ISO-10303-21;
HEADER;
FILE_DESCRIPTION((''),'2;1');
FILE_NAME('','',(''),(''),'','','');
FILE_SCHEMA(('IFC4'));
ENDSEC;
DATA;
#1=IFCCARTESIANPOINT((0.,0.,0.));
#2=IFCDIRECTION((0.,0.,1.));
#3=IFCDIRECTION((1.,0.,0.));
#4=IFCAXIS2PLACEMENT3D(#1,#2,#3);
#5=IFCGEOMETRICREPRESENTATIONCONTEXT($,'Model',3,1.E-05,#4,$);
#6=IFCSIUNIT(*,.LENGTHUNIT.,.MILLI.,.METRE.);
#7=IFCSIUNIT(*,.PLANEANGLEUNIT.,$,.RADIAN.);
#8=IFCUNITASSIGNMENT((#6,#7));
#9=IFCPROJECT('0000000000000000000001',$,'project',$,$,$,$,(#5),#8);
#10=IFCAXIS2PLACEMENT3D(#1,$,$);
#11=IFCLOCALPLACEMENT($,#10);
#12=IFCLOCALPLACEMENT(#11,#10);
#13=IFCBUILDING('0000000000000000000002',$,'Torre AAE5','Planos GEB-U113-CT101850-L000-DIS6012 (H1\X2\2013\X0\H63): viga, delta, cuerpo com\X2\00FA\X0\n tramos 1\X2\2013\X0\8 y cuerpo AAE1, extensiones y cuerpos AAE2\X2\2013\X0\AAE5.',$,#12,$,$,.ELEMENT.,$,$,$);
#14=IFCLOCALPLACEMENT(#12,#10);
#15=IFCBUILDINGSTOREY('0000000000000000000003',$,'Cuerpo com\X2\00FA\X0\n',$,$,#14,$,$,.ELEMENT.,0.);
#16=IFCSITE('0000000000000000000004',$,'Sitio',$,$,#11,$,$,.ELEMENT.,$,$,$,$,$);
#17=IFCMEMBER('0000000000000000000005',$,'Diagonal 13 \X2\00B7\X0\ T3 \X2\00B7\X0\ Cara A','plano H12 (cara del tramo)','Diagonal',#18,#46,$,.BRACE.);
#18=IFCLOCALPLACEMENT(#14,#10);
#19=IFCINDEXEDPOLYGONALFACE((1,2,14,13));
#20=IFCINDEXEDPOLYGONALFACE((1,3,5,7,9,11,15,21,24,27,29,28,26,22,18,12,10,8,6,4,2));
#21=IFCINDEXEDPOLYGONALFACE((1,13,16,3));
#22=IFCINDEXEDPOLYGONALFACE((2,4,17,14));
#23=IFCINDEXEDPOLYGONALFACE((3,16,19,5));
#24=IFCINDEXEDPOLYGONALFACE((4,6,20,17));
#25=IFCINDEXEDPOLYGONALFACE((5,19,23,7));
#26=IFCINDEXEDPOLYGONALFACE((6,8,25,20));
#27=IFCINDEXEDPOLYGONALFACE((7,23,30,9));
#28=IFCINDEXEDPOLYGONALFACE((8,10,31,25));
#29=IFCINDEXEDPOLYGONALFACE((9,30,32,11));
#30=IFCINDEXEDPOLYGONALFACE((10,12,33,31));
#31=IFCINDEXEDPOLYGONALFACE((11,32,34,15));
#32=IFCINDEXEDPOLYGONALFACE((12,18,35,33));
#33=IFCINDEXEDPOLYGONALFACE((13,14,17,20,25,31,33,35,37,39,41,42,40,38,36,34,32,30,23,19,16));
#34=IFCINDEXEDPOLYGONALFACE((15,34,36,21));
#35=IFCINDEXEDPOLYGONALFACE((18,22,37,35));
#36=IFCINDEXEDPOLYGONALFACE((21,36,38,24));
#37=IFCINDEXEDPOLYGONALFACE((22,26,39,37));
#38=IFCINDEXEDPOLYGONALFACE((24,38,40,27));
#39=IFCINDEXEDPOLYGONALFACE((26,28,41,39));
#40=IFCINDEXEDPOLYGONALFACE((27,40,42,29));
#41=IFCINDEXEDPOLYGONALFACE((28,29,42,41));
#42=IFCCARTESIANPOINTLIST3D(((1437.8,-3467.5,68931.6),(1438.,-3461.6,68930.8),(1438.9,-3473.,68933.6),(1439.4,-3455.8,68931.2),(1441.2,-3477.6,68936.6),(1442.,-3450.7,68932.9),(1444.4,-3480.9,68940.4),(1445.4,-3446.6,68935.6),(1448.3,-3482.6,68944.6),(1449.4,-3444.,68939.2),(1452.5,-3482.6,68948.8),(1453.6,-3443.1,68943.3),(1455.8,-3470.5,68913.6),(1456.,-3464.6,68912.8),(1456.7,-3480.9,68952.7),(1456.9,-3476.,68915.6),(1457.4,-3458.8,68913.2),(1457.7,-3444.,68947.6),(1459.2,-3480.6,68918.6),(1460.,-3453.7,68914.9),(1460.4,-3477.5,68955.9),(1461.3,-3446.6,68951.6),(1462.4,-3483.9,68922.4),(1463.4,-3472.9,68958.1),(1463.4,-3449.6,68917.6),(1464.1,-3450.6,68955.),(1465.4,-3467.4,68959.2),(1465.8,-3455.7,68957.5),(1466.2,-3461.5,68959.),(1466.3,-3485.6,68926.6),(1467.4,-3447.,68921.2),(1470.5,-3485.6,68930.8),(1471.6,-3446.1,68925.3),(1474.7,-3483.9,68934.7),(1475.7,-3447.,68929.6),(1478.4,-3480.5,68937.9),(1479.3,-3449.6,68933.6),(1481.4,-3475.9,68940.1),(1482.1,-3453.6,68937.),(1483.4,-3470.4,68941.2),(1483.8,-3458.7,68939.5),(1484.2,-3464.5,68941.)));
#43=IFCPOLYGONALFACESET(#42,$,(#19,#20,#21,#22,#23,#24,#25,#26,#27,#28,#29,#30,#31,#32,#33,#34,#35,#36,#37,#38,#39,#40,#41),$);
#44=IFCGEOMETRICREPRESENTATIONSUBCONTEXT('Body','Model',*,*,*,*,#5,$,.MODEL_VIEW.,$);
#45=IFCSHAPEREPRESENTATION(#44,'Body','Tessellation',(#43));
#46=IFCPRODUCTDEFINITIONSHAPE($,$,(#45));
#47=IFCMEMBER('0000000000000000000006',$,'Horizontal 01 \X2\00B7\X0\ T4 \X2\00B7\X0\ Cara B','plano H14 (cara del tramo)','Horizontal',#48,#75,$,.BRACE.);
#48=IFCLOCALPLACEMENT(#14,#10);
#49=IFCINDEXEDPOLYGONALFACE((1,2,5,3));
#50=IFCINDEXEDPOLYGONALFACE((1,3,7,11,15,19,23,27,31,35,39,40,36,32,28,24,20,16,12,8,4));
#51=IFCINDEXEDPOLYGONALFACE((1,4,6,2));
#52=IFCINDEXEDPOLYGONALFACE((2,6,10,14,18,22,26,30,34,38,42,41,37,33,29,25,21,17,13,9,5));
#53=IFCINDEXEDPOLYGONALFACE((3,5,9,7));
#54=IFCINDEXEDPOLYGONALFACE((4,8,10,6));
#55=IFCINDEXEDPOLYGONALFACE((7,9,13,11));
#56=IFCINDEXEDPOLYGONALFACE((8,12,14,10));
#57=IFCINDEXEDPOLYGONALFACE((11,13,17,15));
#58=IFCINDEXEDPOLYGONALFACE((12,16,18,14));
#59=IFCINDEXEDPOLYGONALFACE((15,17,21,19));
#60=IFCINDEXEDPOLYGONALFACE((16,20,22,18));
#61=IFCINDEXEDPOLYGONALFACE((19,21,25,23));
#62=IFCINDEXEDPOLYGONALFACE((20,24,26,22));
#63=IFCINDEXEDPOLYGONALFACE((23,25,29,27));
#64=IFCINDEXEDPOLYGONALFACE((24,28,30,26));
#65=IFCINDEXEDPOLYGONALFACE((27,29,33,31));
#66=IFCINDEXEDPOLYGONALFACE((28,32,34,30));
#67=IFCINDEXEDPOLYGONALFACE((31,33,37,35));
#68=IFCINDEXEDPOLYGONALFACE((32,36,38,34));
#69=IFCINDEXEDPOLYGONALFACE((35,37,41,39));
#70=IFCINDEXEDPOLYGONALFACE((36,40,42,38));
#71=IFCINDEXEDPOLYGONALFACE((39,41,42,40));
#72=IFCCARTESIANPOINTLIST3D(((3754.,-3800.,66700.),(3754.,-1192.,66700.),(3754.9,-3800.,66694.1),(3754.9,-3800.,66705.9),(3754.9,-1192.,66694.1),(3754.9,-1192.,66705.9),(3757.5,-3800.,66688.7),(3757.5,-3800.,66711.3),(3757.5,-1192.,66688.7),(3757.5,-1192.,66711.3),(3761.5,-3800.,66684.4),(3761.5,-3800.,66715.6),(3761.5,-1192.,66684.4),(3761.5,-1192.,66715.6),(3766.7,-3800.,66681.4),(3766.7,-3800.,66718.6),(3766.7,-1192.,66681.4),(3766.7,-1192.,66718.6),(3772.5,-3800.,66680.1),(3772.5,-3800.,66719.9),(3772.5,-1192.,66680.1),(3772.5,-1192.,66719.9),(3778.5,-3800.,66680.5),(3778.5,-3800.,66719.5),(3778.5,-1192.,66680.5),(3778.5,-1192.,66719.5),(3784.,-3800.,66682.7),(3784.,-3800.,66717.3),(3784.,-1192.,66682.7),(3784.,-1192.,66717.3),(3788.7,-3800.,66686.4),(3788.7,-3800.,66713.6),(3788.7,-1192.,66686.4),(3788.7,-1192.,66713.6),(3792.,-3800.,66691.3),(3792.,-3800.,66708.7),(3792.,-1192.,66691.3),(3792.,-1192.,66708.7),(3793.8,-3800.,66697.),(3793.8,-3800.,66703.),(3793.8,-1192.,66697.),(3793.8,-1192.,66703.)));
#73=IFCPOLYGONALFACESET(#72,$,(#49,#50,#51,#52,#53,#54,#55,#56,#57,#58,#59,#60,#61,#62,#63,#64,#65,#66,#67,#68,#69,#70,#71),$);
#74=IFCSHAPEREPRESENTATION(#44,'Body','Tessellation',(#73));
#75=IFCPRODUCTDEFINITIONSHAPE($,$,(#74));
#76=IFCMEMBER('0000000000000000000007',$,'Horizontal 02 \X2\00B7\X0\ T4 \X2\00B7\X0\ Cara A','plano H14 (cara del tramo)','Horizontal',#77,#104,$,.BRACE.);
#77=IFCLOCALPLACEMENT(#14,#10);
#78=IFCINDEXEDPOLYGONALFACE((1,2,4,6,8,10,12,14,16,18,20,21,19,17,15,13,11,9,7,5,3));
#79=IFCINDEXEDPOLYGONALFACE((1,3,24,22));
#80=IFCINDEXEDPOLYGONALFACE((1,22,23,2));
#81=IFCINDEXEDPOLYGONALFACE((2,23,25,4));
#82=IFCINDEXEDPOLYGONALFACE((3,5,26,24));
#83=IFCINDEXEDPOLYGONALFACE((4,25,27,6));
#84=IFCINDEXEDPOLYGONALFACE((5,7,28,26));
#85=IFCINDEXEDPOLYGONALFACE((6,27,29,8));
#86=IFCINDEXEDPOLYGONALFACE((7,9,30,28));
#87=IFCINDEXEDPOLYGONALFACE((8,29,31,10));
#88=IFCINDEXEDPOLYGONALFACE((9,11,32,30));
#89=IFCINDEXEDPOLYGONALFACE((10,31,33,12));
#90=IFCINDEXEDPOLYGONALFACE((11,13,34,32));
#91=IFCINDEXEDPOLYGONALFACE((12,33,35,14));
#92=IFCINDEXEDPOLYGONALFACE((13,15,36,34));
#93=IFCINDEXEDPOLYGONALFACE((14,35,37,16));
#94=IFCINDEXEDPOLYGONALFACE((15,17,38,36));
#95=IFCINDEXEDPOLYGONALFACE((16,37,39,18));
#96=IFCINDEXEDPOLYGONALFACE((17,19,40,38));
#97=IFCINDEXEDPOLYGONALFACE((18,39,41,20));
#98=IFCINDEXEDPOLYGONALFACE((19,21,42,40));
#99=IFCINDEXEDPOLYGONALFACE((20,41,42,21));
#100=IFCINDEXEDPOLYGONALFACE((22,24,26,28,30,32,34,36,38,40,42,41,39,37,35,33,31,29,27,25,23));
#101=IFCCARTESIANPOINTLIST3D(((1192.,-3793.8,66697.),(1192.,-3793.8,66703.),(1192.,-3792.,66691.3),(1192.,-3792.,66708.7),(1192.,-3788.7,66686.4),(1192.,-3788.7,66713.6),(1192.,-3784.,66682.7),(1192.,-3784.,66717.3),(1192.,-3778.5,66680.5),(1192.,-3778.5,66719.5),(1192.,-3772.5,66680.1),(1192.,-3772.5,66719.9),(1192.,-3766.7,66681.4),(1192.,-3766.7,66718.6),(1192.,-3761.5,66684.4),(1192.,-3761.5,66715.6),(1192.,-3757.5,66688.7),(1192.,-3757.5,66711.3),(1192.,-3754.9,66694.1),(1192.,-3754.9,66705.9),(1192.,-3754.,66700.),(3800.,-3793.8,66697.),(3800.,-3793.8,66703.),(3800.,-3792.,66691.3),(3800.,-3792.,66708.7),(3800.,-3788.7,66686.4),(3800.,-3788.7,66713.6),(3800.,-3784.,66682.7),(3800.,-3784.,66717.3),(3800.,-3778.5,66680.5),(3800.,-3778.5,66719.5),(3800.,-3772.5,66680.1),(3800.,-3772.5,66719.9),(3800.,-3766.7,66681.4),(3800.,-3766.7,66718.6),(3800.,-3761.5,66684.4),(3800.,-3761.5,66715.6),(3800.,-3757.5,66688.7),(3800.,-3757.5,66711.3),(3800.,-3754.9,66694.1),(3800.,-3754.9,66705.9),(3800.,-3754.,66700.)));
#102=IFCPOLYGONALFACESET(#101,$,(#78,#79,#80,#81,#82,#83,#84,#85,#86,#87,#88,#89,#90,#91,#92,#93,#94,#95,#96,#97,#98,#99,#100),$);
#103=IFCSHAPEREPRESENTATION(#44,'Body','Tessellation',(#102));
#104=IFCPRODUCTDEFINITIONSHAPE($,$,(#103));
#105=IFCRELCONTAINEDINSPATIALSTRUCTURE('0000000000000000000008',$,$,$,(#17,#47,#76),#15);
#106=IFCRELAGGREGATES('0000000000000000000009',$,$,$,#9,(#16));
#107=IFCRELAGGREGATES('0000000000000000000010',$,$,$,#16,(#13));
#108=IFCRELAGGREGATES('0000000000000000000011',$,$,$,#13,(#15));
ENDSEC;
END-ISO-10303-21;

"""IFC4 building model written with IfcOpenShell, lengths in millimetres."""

from ifc_helpers import new_model, si_unit, frame, origin, origin_with_axes, place, context, subcontext, project, spatial, circle, extrude, element, save


model = new_model("IFC4")

# Units and contexts
model_context = context("Model", 3, precision=1e-05, world=origin_with_axes())
body_context = subcontext(model_context, "Body", "Model", "MODEL_VIEW")
ifc_project = project(units=[si_unit("LENGTHUNIT", "METRE", prefix="MILLI"), si_unit("PLANEANGLEUNIT", "RADIAN")], contexts=[model_context])

# Site, building, storey
site_placement = place(None, origin())
site = spatial("IfcSite", under=ifc_project, at=site_placement, Name="Sitio", CompositionType="ELEMENT")
building_placement = place(site_placement, origin())
building = spatial("IfcBuilding", under=site, at=building_placement, Name="Torre AAE5", Description="Planos GEB-U113-CT101850-L000-DIS6012 (H1–H63): viga, delta, cuerpo común tramos 1–8 y cuerpo AAE1, extensiones y cuerpos AAE2–AAE5.", CompositionType="ELEMENT")
storey_placement = place(building_placement, origin())
storey = spatial("IfcBuildingStorey", under=building, at=storey_placement, Name="Cuerpo común", CompositionType="ELEMENT", Elevation=0.0)

# Members
member_1_placement = place(storey_placement, frame((1452.0, -3463.0, 68945.0), z_axis=(0.702247, -0.117041, -0.702247), x_axis=(-0.131084, 0.948273, -0.289129)))
element("IfcMember", 1, at=member_1_placement, inside=storey, Name="Diagonal 13 · T3 · Cara A", Description="plano H12 (cara del tramo)", ObjectType="Diagonal", PredefinedType="BRACE", context=body_context, shape_type="SweptSolid", body=[
    extrude(circle(Radius=20.0), None, (0.0, 0.0, 1.0), 25.6),
])
for number, where, z_axis, x_axis, name in (
    (2, (3774.0, -3800.0, 66700.0), (0.0, 1.0, 0.0), (-1.0, 0.0, 0.0), "Horizontal 01 · T4 · Cara B"),
    (3, (3800.0, -3774.0, 66700.0), (-1.0, 0.0, 0.0), (0.0, 1.0, 0.0), "Horizontal 02 · T4 · Cara A"),
):
    element("IfcMember", number, at=place(storey_placement, frame(where, z_axis=z_axis, x_axis=x_axis)), inside=storey, Name=name, Description="plano H14 (cara del tramo)", ObjectType="Horizontal", PredefinedType="BRACE", context=body_context, shape_type="SweptSolid", body=[
        extrude(circle(Radius=20.0), None, (0.0, 0.0, 1.0), 2608.0),
    ])

save(model, "model.ifc")
